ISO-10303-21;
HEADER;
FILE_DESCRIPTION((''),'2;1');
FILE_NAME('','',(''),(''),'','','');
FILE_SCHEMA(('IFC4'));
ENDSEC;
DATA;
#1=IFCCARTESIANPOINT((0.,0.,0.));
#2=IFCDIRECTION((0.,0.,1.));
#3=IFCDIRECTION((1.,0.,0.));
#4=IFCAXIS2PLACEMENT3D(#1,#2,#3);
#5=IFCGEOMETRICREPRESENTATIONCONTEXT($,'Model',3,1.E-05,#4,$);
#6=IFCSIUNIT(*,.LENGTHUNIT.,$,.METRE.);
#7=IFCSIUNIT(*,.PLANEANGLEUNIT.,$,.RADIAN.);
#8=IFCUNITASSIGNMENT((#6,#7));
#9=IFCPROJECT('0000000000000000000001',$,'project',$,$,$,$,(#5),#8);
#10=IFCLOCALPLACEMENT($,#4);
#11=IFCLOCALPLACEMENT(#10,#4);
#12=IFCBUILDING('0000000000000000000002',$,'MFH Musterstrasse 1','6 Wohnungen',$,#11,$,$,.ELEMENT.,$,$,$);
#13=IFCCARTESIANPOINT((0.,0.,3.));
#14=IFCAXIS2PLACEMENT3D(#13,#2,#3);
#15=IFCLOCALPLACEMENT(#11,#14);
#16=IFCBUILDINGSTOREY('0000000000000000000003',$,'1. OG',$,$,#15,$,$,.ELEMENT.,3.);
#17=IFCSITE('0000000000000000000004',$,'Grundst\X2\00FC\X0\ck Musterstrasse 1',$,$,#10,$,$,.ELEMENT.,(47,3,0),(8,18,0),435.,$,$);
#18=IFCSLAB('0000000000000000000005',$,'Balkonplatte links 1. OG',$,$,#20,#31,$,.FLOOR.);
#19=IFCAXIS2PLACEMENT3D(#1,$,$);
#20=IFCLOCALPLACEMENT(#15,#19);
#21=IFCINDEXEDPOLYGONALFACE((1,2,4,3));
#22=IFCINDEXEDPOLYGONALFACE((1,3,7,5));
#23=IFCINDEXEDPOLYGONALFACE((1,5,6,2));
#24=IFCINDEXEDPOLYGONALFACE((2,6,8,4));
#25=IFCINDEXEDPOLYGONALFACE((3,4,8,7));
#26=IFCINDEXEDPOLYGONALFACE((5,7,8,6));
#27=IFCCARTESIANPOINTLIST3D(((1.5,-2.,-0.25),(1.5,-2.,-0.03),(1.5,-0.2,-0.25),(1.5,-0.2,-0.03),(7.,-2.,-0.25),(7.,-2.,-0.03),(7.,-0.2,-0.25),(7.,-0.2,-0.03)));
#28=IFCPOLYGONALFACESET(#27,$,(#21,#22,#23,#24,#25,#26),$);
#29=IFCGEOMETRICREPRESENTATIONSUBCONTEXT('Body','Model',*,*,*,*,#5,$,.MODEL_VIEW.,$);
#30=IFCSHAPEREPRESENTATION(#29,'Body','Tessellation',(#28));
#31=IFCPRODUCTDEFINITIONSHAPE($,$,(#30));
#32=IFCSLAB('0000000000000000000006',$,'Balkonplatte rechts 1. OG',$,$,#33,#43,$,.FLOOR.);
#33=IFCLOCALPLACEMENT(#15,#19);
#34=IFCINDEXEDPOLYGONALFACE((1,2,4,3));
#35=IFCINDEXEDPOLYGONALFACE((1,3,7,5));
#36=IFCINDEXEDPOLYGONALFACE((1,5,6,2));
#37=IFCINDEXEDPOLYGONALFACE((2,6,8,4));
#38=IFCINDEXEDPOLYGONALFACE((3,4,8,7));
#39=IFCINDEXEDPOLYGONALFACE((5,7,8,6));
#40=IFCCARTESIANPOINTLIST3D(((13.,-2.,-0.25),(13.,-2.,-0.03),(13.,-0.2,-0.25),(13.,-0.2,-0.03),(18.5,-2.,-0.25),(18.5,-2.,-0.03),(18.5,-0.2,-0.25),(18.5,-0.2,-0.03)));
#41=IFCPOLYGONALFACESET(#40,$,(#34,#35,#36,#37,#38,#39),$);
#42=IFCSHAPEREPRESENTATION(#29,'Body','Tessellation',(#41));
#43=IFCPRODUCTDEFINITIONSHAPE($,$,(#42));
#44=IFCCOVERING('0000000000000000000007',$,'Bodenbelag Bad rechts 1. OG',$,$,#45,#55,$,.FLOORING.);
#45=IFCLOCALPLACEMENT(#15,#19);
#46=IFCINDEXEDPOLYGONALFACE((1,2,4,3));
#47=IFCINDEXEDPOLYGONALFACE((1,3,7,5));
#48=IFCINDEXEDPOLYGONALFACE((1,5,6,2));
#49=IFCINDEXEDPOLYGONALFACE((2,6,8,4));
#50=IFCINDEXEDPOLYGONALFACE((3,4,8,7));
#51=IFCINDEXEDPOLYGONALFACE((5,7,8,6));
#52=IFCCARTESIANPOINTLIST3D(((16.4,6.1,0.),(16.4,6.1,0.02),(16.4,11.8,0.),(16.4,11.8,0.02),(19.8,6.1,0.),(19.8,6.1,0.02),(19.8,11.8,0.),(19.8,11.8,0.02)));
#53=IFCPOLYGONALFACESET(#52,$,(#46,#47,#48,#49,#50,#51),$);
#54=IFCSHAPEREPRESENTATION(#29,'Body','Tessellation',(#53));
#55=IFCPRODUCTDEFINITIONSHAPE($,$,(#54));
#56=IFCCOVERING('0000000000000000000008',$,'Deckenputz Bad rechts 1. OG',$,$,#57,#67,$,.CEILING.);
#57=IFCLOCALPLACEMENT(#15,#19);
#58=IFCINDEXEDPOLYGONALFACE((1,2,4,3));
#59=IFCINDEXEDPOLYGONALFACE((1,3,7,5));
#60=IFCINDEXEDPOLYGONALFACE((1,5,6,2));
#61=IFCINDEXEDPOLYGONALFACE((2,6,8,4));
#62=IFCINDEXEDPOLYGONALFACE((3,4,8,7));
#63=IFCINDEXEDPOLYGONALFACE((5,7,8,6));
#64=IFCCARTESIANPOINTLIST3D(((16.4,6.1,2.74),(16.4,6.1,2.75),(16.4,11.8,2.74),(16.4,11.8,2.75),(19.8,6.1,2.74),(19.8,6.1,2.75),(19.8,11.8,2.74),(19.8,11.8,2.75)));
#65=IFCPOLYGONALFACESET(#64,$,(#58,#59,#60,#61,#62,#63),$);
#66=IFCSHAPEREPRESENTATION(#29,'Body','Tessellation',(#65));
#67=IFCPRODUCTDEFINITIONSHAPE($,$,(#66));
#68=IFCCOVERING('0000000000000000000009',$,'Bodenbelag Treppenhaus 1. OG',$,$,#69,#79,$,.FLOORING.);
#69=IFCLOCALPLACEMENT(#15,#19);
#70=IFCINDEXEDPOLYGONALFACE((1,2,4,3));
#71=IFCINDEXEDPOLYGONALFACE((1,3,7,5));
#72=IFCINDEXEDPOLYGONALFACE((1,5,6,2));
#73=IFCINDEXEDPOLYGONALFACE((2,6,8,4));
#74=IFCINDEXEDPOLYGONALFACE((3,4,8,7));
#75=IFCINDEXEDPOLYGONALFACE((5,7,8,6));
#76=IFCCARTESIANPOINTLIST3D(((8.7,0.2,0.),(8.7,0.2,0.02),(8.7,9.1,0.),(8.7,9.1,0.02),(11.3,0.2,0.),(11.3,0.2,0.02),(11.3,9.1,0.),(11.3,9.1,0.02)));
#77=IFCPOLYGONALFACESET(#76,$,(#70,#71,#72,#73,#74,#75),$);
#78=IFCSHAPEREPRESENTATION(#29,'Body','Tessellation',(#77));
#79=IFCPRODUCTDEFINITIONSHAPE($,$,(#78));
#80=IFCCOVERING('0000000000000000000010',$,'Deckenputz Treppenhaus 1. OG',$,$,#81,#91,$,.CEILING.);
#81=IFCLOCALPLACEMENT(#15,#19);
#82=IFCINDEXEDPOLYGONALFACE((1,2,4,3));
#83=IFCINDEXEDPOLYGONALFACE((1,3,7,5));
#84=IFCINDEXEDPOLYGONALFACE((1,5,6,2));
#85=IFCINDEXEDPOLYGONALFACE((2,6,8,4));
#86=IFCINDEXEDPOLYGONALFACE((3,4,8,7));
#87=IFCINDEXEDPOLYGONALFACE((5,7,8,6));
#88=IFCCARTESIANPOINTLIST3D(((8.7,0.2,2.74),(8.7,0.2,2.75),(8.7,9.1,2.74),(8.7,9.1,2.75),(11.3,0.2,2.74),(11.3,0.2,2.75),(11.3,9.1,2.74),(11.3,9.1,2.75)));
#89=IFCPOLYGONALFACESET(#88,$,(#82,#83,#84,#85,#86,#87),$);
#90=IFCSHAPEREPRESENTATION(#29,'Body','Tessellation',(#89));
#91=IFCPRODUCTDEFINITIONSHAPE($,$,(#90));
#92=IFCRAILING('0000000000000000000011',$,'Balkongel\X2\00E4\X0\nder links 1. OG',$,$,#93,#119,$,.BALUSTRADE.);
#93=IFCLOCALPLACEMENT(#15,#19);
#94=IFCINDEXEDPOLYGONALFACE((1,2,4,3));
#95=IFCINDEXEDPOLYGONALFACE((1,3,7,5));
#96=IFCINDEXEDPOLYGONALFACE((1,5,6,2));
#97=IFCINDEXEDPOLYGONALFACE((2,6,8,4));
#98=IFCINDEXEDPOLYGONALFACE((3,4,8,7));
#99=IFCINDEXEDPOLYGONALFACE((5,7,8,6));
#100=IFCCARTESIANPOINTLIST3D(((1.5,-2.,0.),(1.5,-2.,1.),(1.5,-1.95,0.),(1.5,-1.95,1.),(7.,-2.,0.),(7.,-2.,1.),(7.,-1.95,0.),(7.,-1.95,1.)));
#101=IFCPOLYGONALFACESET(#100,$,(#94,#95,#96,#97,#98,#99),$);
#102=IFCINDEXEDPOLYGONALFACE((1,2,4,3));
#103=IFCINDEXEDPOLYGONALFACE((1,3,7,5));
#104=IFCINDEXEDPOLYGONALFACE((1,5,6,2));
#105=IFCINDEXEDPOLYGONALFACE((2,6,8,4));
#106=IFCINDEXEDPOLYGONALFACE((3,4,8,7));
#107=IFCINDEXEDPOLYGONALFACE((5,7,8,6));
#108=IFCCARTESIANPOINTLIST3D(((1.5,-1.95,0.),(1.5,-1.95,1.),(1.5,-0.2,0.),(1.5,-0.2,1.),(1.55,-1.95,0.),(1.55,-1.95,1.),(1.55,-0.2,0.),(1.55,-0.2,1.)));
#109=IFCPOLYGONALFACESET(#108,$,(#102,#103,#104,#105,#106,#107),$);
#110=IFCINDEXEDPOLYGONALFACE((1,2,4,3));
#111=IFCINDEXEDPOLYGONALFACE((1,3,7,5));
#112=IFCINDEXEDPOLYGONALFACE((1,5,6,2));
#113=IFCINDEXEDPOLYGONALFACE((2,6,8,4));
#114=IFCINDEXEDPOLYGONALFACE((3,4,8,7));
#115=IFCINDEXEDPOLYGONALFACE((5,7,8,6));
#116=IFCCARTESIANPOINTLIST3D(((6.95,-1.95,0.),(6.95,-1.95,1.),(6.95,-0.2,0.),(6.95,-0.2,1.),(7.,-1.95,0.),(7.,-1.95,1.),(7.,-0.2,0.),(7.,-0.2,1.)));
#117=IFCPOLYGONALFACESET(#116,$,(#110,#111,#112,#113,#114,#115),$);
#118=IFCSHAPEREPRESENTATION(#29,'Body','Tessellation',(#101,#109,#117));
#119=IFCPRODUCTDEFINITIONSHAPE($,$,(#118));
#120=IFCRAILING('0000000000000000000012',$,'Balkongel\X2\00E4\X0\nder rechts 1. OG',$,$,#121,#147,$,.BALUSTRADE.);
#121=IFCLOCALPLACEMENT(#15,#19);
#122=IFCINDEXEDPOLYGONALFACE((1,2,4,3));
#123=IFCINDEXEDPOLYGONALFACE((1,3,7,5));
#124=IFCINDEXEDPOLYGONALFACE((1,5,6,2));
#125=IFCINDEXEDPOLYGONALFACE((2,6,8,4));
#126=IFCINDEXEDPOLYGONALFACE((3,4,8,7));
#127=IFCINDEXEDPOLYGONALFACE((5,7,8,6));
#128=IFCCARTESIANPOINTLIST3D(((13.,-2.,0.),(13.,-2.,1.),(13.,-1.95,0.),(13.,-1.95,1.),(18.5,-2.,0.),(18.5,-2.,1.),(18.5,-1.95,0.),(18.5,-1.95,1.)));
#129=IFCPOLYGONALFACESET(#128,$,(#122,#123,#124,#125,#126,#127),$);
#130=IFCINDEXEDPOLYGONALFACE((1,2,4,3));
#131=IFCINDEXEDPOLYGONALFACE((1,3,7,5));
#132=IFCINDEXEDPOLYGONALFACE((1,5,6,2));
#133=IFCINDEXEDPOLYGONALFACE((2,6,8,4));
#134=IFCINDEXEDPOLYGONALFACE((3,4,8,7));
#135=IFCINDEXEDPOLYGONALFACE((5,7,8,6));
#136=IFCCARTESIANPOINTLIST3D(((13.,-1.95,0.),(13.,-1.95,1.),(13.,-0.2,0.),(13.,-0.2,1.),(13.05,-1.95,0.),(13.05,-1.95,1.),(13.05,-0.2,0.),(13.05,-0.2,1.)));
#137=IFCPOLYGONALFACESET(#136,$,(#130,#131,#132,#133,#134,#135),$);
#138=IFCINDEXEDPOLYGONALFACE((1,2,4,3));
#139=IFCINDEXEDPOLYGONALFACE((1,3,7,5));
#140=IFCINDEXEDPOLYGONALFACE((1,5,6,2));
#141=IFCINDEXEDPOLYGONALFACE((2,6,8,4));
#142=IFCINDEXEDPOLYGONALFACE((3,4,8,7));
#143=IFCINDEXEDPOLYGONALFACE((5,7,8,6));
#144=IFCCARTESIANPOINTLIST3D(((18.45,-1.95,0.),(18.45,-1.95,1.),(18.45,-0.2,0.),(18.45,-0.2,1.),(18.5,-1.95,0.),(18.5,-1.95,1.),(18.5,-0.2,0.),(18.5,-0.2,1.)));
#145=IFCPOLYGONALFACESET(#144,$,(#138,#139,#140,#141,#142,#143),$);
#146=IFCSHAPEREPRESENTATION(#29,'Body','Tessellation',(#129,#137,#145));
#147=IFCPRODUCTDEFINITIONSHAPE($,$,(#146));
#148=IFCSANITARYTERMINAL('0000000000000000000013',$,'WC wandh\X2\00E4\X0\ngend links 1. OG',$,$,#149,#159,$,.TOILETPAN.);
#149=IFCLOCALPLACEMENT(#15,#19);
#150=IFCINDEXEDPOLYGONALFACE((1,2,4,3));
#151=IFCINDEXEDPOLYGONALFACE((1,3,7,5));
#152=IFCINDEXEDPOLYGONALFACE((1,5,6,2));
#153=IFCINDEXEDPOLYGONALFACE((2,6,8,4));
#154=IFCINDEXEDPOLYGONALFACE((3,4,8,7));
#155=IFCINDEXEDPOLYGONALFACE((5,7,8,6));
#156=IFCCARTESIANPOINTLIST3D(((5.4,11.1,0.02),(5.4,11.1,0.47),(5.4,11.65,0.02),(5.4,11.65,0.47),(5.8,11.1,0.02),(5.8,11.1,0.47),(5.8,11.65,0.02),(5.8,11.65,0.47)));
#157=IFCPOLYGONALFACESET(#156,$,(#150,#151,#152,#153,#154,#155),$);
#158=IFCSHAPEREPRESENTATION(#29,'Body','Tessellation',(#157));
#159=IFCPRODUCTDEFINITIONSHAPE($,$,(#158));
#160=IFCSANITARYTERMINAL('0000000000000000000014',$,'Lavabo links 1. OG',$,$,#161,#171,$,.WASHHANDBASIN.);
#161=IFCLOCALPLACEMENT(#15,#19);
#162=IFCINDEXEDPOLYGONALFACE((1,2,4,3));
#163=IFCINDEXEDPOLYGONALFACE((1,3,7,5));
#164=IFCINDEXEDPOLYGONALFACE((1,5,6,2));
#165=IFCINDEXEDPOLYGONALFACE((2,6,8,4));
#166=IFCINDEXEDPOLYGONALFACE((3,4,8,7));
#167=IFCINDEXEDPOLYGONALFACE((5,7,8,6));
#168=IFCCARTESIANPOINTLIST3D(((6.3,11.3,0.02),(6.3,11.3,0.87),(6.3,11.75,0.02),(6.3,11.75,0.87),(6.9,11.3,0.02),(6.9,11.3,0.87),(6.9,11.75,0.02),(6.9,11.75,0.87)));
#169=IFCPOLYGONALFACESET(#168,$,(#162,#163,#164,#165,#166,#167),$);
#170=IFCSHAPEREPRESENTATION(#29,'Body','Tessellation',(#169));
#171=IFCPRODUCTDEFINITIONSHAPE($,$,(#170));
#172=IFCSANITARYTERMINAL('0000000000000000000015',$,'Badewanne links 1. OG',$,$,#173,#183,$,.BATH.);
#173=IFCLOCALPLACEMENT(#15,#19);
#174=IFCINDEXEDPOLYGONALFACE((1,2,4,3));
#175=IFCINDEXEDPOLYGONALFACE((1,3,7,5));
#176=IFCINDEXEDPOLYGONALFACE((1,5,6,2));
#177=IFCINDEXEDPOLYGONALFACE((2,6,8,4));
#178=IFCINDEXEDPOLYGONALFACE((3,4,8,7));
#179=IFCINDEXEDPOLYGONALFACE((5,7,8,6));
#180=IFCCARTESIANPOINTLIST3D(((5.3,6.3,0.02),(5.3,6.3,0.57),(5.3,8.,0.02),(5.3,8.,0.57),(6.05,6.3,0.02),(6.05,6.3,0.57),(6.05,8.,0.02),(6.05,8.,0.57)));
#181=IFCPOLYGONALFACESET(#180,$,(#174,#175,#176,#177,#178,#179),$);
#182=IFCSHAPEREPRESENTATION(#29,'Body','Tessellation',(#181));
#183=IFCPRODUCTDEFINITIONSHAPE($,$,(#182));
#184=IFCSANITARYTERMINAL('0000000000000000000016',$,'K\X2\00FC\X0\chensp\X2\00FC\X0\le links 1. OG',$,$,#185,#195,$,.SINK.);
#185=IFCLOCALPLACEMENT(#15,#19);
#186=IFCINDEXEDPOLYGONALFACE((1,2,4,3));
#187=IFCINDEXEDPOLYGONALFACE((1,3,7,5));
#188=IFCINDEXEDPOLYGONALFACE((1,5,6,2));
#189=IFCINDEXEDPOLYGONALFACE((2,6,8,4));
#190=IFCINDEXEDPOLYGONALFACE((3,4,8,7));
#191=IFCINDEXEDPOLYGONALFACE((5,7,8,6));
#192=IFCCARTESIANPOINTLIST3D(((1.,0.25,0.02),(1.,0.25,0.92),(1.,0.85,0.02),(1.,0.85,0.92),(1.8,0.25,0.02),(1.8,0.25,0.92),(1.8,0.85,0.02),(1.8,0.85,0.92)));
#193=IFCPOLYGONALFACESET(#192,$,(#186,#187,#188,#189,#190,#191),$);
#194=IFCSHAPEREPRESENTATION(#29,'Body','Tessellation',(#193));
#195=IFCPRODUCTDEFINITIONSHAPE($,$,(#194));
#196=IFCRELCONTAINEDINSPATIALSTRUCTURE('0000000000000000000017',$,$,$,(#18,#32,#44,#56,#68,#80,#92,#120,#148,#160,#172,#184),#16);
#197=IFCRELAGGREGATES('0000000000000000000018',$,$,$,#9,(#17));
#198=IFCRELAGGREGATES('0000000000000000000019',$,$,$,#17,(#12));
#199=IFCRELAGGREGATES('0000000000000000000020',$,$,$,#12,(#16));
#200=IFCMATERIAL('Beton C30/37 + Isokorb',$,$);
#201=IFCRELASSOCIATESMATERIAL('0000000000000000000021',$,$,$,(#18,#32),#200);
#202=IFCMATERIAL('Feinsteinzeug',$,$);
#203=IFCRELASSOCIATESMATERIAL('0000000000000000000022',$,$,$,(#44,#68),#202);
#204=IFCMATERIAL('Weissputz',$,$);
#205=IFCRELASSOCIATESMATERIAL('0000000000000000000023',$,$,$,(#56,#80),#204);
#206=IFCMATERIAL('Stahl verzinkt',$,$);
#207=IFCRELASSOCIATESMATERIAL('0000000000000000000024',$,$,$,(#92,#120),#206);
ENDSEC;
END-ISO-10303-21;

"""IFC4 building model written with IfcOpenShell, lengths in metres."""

from ifc_helpers import new_model, si_unit, frame, frame_2d, origin_with_axes, place, context, subcontext, project, spatial, rectangle, extrude, material, element, save


model = new_model("IFC4")

# Units and contexts
model_context = context("Model", 3, precision=1e-05, world=origin_with_axes())
body_context = subcontext(model_context, "Body", "Model", "MODEL_VIEW")
ifc_project = project(units=[si_unit("LENGTHUNIT", "METRE"), si_unit("PLANEANGLEUNIT", "RADIAN")], contexts=[model_context])

# Site, building, storey
site_placement = place(None, origin_with_axes())
site = spatial("IfcSite", under=ifc_project, at=site_placement, Name="Grundstück Musterstrasse 1", CompositionType="ELEMENT", RefLatitude=(47, 3, 0), RefLongitude=(8, 18, 0), RefElevation=435.0)
building_placement = place(site_placement, origin_with_axes())
building = spatial("IfcBuilding", under=site, at=building_placement, Name="MFH Musterstrasse 1", Description="6 Wohnungen", CompositionType="ELEMENT")
storey_placement = place(building_placement, frame((0.0, 0.0, 3.0), z_axis=(0.0, 0.0, 1.0), x_axis=(1.0, 0.0, 0.0)))
storey = spatial("IfcBuildingStorey", under=building, at=storey_placement, Name="1. OG", CompositionType="ELEMENT", Elevation=3.0)

# Slabs
ifc_material_1 = material(Name="Beton C30/37 + Isokorb")
slab_1_placement = place(storey_placement, origin_with_axes())
element("IfcSlab", 1, at=slab_1_placement, inside=storey, material=ifc_material_1, Name="Balkonplatte links 1. OG", PredefinedType="FLOOR", context=body_context, shape_type="SweptSolid", body=[
    extrude(rectangle(XDim=5.5, YDim=1.8, at=frame_2d((2.75, 0.9), x_axis=(1.0, 0.0))), frame((1.5, -2.0, -0.25), z_axis=(0.0, 0.0, 1.0), x_axis=(1.0, 0.0, 0.0)), (0.0, 0.0, 1.0), 0.22),
])
slab_2_placement = place(storey_placement, origin_with_axes())
element("IfcSlab", 2, at=slab_2_placement, inside=storey, material=ifc_material_1, Name="Balkonplatte rechts 1. OG", PredefinedType="FLOOR", context=body_context, shape_type="SweptSolid", body=[
    extrude(rectangle(XDim=5.5, YDim=1.8, at=frame_2d((2.75, 0.9), x_axis=(1.0, 0.0))), frame((13.0, -2.0, -0.25), z_axis=(0.0, 0.0, 1.0), x_axis=(1.0, 0.0, 0.0)), (0.0, 0.0, 1.0), 0.22),
])

# Coverings
ifc_material_2 = material(Name="Feinsteinzeug")
covering_1_placement = place(storey_placement, origin_with_axes())
element("IfcCovering", 3, at=covering_1_placement, inside=storey, material=ifc_material_2, Name="Bodenbelag Bad rechts 1. OG", PredefinedType="FLOORING", context=body_context, shape_type="SweptSolid", body=[
    extrude(rectangle(XDim=3.4, YDim=5.7, at=frame_2d((1.7, 2.85), x_axis=(1.0, 0.0))), frame((16.4, 6.1, 0.0), z_axis=(0.0, 0.0, 1.0), x_axis=(1.0, 0.0, 0.0)), (0.0, 0.0, 1.0), 0.02),
])
ifc_material_3 = material(Name="Weissputz")
covering_2_placement = place(storey_placement, origin_with_axes())
element("IfcCovering", 4, at=covering_2_placement, inside=storey, material=ifc_material_3, Name="Deckenputz Bad rechts 1. OG", PredefinedType="CEILING", context=body_context, shape_type="SweptSolid", body=[
    extrude(rectangle(XDim=3.4, YDim=5.7, at=frame_2d((1.7, 2.85), x_axis=(1.0, 0.0))), frame((16.4, 6.1, 2.74), z_axis=(0.0, 0.0, 1.0), x_axis=(1.0, 0.0, 0.0)), (0.0, 0.0, 1.0), 0.01),
])
covering_3_placement = place(storey_placement, origin_with_axes())
element("IfcCovering", 5, at=covering_3_placement, inside=storey, material=ifc_material_2, Name="Bodenbelag Treppenhaus 1. OG", PredefinedType="FLOORING", context=body_context, shape_type="SweptSolid", body=[
    extrude(rectangle(XDim=2.6, YDim=8.9, at=frame_2d((1.3, 4.45), x_axis=(1.0, 0.0))), frame((8.7, 0.2, 0.0), z_axis=(0.0, 0.0, 1.0), x_axis=(1.0, 0.0, 0.0)), (0.0, 0.0, 1.0), 0.02),
])
covering_4_placement = place(storey_placement, origin_with_axes())
element("IfcCovering", 6, at=covering_4_placement, inside=storey, material=ifc_material_3, Name="Deckenputz Treppenhaus 1. OG", PredefinedType="CEILING", context=body_context, shape_type="SweptSolid", body=[
    extrude(rectangle(XDim=2.6, YDim=8.9, at=frame_2d((1.3, 4.45), x_axis=(1.0, 0.0))), frame((8.7, 0.2, 2.74), z_axis=(0.0, 0.0, 1.0), x_axis=(1.0, 0.0, 0.0)), (0.0, 0.0, 1.0), 0.01),
])

# Railings
ifc_material_4 = material(Name="Stahl verzinkt")
railing_1_placement = place(storey_placement, origin_with_axes())
element("IfcRailing", 7, at=railing_1_placement, inside=storey, material=ifc_material_4, Name="Balkongeländer links 1. OG", PredefinedType="BALUSTRADE", context=body_context, shape_type="SweptSolid", body=[
    extrude(rectangle(XDim=5.5, YDim=0.05, at=frame_2d((2.75, 0.025), x_axis=(1.0, 0.0))), frame((1.5, -2.0, 0.0), z_axis=(0.0, 0.0, 1.0), x_axis=(1.0, 0.0, 0.0)), (0.0, 0.0, 1.0), 1.0),
    extrude(rectangle(XDim=0.05, YDim=1.75, at=frame_2d((0.025, 0.875), x_axis=(1.0, 0.0))), frame((1.5, -1.95, 0.0), z_axis=(0.0, 0.0, 1.0), x_axis=(1.0, 0.0, 0.0)), (0.0, 0.0, 1.0), 1.0),
    extrude(rectangle(XDim=0.05, YDim=1.75, at=frame_2d((0.025, 0.875), x_axis=(1.0, 0.0))), frame((6.95, -1.95, 0.0), z_axis=(0.0, 0.0, 1.0), x_axis=(1.0, 0.0, 0.0)), (0.0, 0.0, 1.0), 1.0),
])
railing_2_placement = place(storey_placement, origin_with_axes())
element("IfcRailing", 8, at=railing_2_placement, inside=storey, material=ifc_material_4, Name="Balkongeländer rechts 1. OG", PredefinedType="BALUSTRADE", context=body_context, shape_type="SweptSolid", body=[
    extrude(rectangle(XDim=5.5, YDim=0.05, at=frame_2d((2.75, 0.025), x_axis=(1.0, 0.0))), frame((13.0, -2.0, 0.0), z_axis=(0.0, 0.0, 1.0), x_axis=(1.0, 0.0, 0.0)), (0.0, 0.0, 1.0), 1.0),
    extrude(rectangle(XDim=0.05, YDim=1.75, at=frame_2d((0.025, 0.875), x_axis=(1.0, 0.0))), frame((13.0, -1.95, 0.0), z_axis=(0.0, 0.0, 1.0), x_axis=(1.0, 0.0, 0.0)), (0.0, 0.0, 1.0), 1.0),
    extrude(rectangle(XDim=0.05, YDim=1.75, at=frame_2d((0.025, 0.875), x_axis=(1.0, 0.0))), frame((18.45, -1.95, 0.0), z_axis=(0.0, 0.0, 1.0), x_axis=(1.0, 0.0, 0.0)), (0.0, 0.0, 1.0), 1.0),
])

# Sanitary terminals
sanitary_terminal_1_placement = place(storey_placement, origin_with_axes())
element("IfcSanitaryTerminal", 9, at=sanitary_terminal_1_placement, inside=storey, Name="WC wandhängend links 1. OG", PredefinedType="TOILETPAN", context=body_context, shape_type="SweptSolid", body=[
    extrude(rectangle(XDim=0.4, YDim=0.55, at=frame_2d((0.2, 0.275), x_axis=(1.0, 0.0))), frame((5.4, 11.1, 0.02), z_axis=(0.0, 0.0, 1.0), x_axis=(1.0, 0.0, 0.0)), (0.0, 0.0, 1.0), 0.45),
])
sanitary_terminal_2_placement = place(storey_placement, origin_with_axes())
element("IfcSanitaryTerminal", 10, at=sanitary_terminal_2_placement, inside=storey, Name="Lavabo links 1. OG", PredefinedType="WASHHANDBASIN", context=body_context, shape_type="SweptSolid", body=[
    extrude(rectangle(XDim=0.6, YDim=0.45, at=frame_2d((0.3, 0.225), x_axis=(1.0, 0.0))), frame((6.3, 11.3, 0.02), z_axis=(0.0, 0.0, 1.0), x_axis=(1.0, 0.0, 0.0)), (0.0, 0.0, 1.0), 0.85),
])
sanitary_terminal_3_placement = place(storey_placement, origin_with_axes())
element("IfcSanitaryTerminal", 11, at=sanitary_terminal_3_placement, inside=storey, Name="Badewanne links 1. OG", PredefinedType="BATH", context=body_context, shape_type="SweptSolid", body=[
    extrude(rectangle(XDim=0.75, YDim=1.7, at=frame_2d((0.375, 0.85), x_axis=(1.0, 0.0))), frame((5.3, 6.3, 0.02), z_axis=(0.0, 0.0, 1.0), x_axis=(1.0, 0.0, 0.0)), (0.0, 0.0, 1.0), 0.55),
])
sanitary_terminal_4_placement = place(storey_placement, origin_with_axes())
element("IfcSanitaryTerminal", 12, at=sanitary_terminal_4_placement, inside=storey, Name="Küchenspüle links 1. OG", PredefinedType="SINK", context=body_context, shape_type="SweptSolid", body=[
    extrude(rectangle(XDim=0.8, YDim=0.6, at=frame_2d((0.4, 0.3), x_axis=(1.0, 0.0))), frame((1.0, 0.25, 0.02), z_axis=(0.0, 0.0, 1.0), x_axis=(1.0, 0.0, 0.0)), (0.0, 0.0, 1.0), 0.9),
])

save(model, "model.ifc")
